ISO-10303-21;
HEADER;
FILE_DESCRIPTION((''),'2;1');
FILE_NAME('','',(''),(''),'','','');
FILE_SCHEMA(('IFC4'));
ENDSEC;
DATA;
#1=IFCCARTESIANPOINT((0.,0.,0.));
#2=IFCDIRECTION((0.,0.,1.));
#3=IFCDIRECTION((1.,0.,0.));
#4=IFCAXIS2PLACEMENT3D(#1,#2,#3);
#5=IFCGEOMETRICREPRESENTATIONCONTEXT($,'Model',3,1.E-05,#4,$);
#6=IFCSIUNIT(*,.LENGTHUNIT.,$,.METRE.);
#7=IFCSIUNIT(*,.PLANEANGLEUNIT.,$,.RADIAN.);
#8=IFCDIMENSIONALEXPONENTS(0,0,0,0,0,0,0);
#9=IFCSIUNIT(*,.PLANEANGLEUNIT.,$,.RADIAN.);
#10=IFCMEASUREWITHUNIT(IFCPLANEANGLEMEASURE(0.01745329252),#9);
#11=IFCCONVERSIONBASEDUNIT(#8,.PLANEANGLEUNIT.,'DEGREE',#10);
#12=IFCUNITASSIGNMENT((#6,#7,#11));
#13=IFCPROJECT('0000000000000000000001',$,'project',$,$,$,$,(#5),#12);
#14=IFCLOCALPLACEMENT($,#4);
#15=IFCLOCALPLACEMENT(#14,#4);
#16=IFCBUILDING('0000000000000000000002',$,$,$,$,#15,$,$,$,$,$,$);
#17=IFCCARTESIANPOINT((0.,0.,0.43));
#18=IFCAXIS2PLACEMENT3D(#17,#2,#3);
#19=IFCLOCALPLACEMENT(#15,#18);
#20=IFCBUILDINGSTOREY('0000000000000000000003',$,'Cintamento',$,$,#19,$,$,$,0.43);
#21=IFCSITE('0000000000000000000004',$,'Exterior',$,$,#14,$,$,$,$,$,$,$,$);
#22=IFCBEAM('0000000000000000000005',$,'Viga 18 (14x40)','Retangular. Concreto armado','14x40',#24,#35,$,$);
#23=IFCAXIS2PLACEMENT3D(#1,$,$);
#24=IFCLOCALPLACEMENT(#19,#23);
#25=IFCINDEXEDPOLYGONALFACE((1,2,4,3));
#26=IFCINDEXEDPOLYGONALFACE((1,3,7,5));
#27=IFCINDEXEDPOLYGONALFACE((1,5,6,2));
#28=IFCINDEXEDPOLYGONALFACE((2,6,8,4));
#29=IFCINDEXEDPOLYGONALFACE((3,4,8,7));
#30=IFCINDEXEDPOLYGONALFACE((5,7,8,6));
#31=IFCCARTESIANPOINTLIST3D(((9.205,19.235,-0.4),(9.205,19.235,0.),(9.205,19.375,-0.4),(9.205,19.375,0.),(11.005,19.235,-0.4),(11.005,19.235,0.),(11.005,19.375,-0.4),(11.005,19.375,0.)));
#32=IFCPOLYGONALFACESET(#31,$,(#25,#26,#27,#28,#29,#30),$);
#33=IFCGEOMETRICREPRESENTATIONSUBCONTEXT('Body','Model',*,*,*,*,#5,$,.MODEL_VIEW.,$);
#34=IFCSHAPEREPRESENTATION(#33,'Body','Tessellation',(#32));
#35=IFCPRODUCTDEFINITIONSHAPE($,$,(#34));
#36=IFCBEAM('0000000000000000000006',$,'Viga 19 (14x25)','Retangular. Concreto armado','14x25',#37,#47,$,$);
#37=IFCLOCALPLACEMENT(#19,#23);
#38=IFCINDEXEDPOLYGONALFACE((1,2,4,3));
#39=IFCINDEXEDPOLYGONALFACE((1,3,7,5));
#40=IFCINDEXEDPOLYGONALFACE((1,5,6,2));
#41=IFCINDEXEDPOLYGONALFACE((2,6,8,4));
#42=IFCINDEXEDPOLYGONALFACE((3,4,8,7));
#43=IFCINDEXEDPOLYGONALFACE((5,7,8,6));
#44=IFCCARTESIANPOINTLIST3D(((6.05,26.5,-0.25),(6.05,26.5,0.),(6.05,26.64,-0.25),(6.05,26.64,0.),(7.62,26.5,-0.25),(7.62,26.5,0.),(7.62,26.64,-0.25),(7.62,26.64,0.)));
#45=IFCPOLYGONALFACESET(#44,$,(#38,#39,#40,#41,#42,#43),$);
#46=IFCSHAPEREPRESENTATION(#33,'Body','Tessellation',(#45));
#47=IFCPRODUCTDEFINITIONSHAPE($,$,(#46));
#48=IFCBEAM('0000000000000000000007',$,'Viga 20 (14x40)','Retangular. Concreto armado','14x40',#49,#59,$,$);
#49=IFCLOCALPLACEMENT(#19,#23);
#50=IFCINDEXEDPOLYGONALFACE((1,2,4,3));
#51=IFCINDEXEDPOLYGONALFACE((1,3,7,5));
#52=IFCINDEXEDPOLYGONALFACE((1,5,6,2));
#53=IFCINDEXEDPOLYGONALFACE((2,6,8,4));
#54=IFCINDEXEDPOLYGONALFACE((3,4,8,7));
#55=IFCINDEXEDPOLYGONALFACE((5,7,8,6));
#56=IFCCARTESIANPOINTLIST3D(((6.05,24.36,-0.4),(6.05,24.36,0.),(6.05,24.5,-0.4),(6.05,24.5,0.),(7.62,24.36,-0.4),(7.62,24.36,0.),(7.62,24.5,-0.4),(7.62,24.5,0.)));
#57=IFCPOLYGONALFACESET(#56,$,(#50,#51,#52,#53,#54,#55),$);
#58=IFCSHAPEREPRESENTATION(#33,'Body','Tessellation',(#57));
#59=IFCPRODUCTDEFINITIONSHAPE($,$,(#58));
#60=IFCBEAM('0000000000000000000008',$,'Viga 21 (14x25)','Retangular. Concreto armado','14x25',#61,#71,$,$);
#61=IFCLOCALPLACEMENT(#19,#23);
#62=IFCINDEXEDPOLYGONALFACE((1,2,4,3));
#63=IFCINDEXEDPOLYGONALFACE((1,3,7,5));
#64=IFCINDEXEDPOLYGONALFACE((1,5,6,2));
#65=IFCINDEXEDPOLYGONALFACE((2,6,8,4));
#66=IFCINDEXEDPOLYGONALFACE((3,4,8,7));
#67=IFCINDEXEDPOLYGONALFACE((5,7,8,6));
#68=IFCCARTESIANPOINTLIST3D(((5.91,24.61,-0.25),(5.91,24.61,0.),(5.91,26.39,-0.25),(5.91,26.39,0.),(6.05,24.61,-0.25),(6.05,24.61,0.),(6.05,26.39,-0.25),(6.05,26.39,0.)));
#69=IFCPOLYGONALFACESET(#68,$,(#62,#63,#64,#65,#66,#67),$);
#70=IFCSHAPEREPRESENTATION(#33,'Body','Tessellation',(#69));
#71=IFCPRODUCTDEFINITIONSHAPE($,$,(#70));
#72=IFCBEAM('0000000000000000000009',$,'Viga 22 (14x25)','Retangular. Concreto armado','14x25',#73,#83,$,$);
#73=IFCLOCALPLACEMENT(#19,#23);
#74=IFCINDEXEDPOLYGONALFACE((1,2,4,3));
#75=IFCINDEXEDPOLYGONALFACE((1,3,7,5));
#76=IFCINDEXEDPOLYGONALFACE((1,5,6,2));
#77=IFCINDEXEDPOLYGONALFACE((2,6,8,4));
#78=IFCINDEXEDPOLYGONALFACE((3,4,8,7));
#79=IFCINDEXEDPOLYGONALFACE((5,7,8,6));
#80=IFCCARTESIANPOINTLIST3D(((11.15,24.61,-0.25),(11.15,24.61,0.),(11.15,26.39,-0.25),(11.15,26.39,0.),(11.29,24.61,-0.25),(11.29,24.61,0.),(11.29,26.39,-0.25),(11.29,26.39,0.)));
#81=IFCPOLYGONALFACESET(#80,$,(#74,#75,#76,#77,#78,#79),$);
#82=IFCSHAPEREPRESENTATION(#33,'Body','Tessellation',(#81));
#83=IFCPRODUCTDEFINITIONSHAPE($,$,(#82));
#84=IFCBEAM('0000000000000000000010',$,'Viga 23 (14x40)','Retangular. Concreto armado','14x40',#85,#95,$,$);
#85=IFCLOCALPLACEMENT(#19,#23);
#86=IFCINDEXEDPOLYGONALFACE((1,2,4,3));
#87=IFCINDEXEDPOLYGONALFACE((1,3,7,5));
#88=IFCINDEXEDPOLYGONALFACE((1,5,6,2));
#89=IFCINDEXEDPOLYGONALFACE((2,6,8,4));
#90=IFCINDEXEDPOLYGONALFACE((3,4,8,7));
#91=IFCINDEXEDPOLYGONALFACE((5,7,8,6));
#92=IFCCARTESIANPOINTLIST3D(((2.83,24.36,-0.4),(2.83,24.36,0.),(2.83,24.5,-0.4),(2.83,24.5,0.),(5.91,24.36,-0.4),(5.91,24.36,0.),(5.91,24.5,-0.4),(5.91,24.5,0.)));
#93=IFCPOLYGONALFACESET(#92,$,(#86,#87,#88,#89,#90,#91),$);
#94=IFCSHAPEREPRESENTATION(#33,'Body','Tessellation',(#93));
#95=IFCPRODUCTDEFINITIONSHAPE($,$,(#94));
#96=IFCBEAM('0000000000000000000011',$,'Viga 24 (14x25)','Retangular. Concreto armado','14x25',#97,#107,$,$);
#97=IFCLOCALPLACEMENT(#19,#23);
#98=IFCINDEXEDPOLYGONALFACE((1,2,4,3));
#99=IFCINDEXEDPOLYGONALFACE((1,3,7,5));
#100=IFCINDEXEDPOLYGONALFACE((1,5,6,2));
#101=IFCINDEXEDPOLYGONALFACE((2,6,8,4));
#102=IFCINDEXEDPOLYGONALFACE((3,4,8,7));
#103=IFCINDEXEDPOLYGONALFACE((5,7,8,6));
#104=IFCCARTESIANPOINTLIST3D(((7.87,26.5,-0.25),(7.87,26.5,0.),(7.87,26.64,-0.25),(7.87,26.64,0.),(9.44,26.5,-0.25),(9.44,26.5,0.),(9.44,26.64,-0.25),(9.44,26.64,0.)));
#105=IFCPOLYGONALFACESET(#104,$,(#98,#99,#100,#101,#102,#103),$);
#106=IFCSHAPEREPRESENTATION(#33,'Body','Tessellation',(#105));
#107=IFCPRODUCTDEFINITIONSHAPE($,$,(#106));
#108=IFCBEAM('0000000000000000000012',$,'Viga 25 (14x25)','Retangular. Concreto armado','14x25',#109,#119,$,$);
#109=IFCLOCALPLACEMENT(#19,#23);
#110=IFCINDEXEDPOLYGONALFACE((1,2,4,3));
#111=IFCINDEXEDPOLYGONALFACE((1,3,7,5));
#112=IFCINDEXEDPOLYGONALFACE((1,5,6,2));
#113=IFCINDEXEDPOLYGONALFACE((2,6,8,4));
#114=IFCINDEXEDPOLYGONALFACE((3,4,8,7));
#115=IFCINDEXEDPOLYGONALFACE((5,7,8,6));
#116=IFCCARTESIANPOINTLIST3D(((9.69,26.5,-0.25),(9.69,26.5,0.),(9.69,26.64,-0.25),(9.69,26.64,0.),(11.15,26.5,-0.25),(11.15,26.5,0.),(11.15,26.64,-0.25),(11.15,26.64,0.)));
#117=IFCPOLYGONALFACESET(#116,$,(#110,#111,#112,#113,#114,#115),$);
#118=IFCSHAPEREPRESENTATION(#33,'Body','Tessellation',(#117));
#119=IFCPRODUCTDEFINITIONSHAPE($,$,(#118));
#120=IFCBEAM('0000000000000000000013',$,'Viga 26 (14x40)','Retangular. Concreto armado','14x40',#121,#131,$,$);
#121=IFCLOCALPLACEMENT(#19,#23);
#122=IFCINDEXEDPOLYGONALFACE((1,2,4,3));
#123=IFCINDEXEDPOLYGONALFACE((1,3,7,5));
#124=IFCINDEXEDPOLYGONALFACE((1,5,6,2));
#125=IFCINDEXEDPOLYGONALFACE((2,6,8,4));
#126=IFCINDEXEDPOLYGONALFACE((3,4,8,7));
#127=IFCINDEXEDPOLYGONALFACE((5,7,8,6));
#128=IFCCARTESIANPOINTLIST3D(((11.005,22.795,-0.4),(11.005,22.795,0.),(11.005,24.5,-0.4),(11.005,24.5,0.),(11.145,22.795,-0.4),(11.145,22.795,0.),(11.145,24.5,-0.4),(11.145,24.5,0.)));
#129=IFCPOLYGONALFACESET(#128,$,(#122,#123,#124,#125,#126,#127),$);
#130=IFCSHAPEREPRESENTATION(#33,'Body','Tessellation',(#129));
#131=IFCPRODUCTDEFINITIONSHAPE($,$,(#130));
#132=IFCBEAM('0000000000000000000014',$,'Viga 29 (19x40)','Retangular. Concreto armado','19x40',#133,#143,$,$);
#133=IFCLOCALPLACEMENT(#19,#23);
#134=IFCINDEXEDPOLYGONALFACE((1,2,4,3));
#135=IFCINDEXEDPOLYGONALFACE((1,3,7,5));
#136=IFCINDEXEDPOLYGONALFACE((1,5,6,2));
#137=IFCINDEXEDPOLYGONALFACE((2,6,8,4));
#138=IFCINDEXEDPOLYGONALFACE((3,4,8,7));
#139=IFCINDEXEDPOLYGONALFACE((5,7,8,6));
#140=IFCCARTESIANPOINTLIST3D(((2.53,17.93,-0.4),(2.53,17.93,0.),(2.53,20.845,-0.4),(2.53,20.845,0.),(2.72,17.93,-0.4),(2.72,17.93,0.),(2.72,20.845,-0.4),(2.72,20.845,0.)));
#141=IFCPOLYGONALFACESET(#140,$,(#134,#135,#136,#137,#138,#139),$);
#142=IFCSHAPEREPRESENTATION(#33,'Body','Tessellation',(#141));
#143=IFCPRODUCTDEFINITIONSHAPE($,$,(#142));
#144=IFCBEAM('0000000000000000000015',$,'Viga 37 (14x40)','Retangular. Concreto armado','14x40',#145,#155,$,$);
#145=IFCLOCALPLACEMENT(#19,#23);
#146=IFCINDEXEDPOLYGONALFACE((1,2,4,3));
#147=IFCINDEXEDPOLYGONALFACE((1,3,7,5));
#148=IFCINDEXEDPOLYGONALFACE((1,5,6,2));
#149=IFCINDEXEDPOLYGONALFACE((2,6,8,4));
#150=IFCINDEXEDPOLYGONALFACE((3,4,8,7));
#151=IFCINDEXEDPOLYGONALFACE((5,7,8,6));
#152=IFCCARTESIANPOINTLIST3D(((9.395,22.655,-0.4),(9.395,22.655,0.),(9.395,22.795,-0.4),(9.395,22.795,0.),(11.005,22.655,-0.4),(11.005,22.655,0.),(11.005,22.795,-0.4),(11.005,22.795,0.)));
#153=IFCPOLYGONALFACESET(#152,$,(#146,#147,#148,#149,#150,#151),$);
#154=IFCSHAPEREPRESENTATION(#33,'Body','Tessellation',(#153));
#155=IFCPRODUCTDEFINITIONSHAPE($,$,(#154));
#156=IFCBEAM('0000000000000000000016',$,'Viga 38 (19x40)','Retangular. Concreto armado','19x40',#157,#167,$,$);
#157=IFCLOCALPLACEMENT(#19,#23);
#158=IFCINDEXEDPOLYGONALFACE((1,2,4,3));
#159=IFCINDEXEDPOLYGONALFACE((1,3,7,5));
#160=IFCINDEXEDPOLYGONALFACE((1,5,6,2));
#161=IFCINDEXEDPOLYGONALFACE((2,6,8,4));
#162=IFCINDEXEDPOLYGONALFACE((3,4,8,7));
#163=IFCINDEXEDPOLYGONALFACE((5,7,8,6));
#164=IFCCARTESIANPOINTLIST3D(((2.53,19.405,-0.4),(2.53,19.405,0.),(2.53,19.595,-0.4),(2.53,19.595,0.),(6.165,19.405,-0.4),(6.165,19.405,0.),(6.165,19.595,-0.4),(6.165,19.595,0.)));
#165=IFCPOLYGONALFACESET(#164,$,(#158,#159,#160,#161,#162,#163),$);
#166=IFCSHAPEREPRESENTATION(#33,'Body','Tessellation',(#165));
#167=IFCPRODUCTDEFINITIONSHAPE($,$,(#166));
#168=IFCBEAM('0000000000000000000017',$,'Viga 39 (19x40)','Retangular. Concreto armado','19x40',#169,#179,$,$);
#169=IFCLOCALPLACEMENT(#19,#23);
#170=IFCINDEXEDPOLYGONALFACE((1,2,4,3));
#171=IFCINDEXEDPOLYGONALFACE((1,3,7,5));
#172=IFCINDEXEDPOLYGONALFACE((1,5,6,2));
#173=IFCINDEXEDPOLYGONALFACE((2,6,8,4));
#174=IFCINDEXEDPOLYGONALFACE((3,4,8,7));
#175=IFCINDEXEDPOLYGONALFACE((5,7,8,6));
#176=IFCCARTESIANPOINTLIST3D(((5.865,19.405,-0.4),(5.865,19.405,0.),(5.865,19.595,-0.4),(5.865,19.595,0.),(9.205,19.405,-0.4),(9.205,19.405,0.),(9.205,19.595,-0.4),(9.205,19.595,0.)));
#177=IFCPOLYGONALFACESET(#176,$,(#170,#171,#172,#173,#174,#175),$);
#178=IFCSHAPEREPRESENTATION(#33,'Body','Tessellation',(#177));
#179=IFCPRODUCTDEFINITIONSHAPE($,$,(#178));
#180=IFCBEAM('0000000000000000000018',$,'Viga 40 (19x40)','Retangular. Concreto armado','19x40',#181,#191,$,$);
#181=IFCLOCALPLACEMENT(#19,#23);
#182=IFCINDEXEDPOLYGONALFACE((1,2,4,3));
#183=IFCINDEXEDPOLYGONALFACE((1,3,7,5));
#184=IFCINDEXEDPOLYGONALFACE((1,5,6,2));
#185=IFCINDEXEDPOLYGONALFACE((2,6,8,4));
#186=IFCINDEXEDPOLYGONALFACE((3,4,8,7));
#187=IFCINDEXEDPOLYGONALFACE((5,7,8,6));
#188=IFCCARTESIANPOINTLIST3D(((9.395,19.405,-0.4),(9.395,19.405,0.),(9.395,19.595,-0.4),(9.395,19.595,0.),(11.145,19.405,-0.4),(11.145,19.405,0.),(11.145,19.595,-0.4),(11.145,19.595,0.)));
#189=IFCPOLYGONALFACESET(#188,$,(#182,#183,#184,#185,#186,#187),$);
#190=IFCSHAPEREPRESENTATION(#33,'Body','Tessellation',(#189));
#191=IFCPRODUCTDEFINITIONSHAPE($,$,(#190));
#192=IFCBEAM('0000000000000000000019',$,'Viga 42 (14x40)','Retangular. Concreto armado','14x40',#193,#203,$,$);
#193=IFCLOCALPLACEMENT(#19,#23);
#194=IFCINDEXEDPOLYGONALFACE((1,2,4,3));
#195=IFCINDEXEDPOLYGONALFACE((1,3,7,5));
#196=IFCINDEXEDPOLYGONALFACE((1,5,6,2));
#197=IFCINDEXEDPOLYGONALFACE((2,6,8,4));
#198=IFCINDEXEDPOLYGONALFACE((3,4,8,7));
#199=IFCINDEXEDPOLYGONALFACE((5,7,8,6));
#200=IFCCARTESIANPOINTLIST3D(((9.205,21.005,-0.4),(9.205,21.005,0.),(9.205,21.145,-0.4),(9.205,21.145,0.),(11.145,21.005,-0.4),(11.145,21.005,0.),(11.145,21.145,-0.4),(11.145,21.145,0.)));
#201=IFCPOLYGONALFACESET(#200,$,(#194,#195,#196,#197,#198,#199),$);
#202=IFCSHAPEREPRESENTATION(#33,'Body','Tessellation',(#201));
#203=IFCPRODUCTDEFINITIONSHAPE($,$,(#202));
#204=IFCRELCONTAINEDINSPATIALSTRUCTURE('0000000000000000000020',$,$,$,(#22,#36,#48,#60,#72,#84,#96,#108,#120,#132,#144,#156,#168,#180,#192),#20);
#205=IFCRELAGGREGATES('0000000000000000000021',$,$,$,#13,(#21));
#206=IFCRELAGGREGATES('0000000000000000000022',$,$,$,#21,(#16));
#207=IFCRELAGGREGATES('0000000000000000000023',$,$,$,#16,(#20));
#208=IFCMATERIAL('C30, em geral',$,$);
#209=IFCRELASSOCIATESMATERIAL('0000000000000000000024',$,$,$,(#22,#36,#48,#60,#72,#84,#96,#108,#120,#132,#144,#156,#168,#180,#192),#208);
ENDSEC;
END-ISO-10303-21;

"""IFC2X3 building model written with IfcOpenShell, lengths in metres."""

from ifc_helpers import new_model, entity, si_unit, converted_unit, frame, frame_2d, origin_with_axes, place, context, subcontext, project, spatial, rectangle, extrude, material, element, save


model = new_model("IFC2X3")

# Units and contexts
model_context = context("Model", 3, precision=1e-05, world=origin_with_axes())
body_context = subcontext(model_context, "Body", "Model", "MODEL_VIEW")
ifc_project = project(units=[si_unit("LENGTHUNIT", "METRE"), si_unit("PLANEANGLEUNIT", "RADIAN"), converted_unit("PLANEANGLEUNIT", "DEGREE", entity("IfcPlaneAngleMeasure", 0.01745329252), si_unit("PLANEANGLEUNIT", "RADIAN"), dimensions=[0, 0, 0, 0, 0, 0, 0])], contexts=[model_context])

# Site, building, storey
site_placement = place(None, origin_with_axes())
site = spatial("IfcSite", under=ifc_project, at=site_placement, Name="Exterior")
building_placement = place(site_placement, origin_with_axes())
building = spatial("IfcBuilding", under=site, at=building_placement)
storey_placement = place(building_placement, frame((0.0, 0.0, 0.43), z_axis=(0.0, 0.0, 1.0), x_axis=(1.0, 0.0, 0.0)))
storey = spatial("IfcBuildingStorey", under=building, at=storey_placement, Name="Cintamento", Elevation=0.43)

# Beams
ifc_material_1 = material(Name="C30, em geral")
beam_1_placement = place(storey_placement, frame((11.005, 19.305, 0.0), z_axis=(-1.0, 0.0, 0.0), x_axis=(0.0, -1.0, 0.0)))
element("IfcBeam", 1, at=beam_1_placement, inside=storey, material=ifc_material_1, Name="Viga 18 (14x40)", Description="Retangular. Concreto armado", ObjectType="14x40", context=body_context, shape_type="SweptSolid", body=[
    extrude(rectangle(XDim=0.14, YDim=0.4, at=frame_2d((0.0, -0.2), x_axis=(1.0, 0.0))), origin_with_axes(), (0.0, 0.0, 1.0), 1.8),
])
beam_2_placement = place(storey_placement, frame((7.62, 26.57, 0.0), z_axis=(-1.0, 0.0, 0.0), x_axis=(0.0, -1.0, 0.0)))
element("IfcBeam", 2, at=beam_2_placement, inside=storey, material=ifc_material_1, Name="Viga 19 (14x25)", Description="Retangular. Concreto armado", ObjectType="14x25", context=body_context, shape_type="SweptSolid", body=[
    extrude(rectangle(XDim=0.14, YDim=0.25, at=frame_2d((0.0, -0.125), x_axis=(1.0, 0.0))), origin_with_axes(), (0.0, 0.0, 1.0), 1.57),
])
beam_3_placement = place(storey_placement, frame((7.62, 24.43, 0.0), z_axis=(-1.0, 0.0, 0.0), x_axis=(0.0, -1.0, 0.0)))
element("IfcBeam", 3, at=beam_3_placement, inside=storey, material=ifc_material_1, Name="Viga 20 (14x40)", Description="Retangular. Concreto armado", ObjectType="14x40", context=body_context, shape_type="SweptSolid", body=[
    extrude(rectangle(XDim=0.14, YDim=0.4, at=frame_2d((0.0, -0.2), x_axis=(1.0, 0.0))), origin_with_axes(), (0.0, 0.0, 1.0), 1.57),
])
for number, where, z_axis, x_axis, name in (
    (4, (5.98, 24.61, 0.0), (0.0, 1.0, 0.0), (-1.0, 0.0, 0.0), "Viga 21 (14x25)"),
    (5, (11.22, 26.39, 0.0), (0.0, -1.0, 0.0), (1.0, 0.0, 0.0), "Viga 22 (14x25)"),
):
    element("IfcBeam", number, at=place(storey_placement, frame(where, z_axis=z_axis, x_axis=x_axis)), inside=storey, material=ifc_material_1, Name=name, Description="Retangular. Concreto armado", ObjectType="14x25", context=body_context, shape_type="SweptSolid", body=[
        extrude(rectangle(XDim=0.14, YDim=0.25, at=frame_2d((0.0, -0.125), x_axis=(1.0, 0.0))), origin_with_axes(), (0.0, 0.0, 1.0), 1.78),
    ])
beam_4_placement = place(storey_placement, frame((5.91, 24.43, 0.0), z_axis=(-1.0, 0.0, 0.0), x_axis=(0.0, -1.0, 0.0)))
element("IfcBeam", 6, at=beam_4_placement, inside=storey, material=ifc_material_1, Name="Viga 23 (14x40)", Description="Retangular. Concreto armado", ObjectType="14x40", context=body_context, shape_type="SweptSolid", body=[
    extrude(rectangle(XDim=0.14, YDim=0.4, at=frame_2d((0.0, -0.2), x_axis=(1.0, 0.0))), origin_with_axes(), (0.0, 0.0, 1.0), 3.08),
])
beam_5_placement = place(storey_placement, frame((7.87, 26.57, 0.0), z_axis=(1.0, 0.0, 0.0), x_axis=(0.0, 1.0, 0.0)))
element("IfcBeam", 7, at=beam_5_placement, inside=storey, material=ifc_material_1, Name="Viga 24 (14x25)", Description="Retangular. Concreto armado", ObjectType="14x25", context=body_context, shape_type="SweptSolid", body=[
    extrude(rectangle(XDim=0.14, YDim=0.25, at=frame_2d((0.0, -0.125), x_axis=(1.0, 0.0))), origin_with_axes(), (0.0, 0.0, 1.0), 1.57),
])
beam_6_placement = place(storey_placement, frame((9.69, 26.57, 0.0), z_axis=(1.0, 0.0, 0.0), x_axis=(0.0, 1.0, 0.0)))
element("IfcBeam", 8, at=beam_6_placement, inside=storey, material=ifc_material_1, Name="Viga 25 (14x25)", Description="Retangular. Concreto armado", ObjectType="14x25", context=body_context, shape_type="SweptSolid", body=[
    extrude(rectangle(XDim=0.14, YDim=0.25, at=frame_2d((0.0, -0.125), x_axis=(1.0, 0.0))), origin_with_axes(), (0.0, 0.0, 1.0), 1.46),
])
beam_7_placement = place(storey_placement, frame((11.075, 22.795, 0.0), z_axis=(0.0, 1.0, 0.0), x_axis=(-1.0, 0.0, 0.0)))
element("IfcBeam", 9, at=beam_7_placement, inside=storey, material=ifc_material_1, Name="Viga 26 (14x40)", Description="Retangular. Concreto armado", ObjectType="14x40", context=body_context, shape_type="SweptSolid", body=[
    extrude(rectangle(XDim=0.14, YDim=0.4, at=frame_2d((0.0, -0.2), x_axis=(1.0, 0.0))), origin_with_axes(), (0.0, 0.0, 1.0), 1.705),
])
beam_8_placement = place(storey_placement, frame((2.625, 17.93, 0.0), z_axis=(0.0, 1.0, 0.0), x_axis=(-1.0, 0.0, 0.0)))
element("IfcBeam", 10, at=beam_8_placement, inside=storey, material=ifc_material_1, Name="Viga 29 (19x40)", Description="Retangular. Concreto armado", ObjectType="19x40", context=body_context, shape_type="SweptSolid", body=[
    extrude(rectangle(XDim=0.19, YDim=0.4, at=frame_2d((0.0, -0.2), x_axis=(1.0, 0.0))), origin_with_axes(), (0.0, 0.0, 1.0), 2.915),
])
beam_9_placement = place(storey_placement, frame((9.395, 22.725, 0.0), z_axis=(1.0, 0.0, 0.0), x_axis=(0.0, 1.0, 0.0)))
element("IfcBeam", 11, at=beam_9_placement, inside=storey, material=ifc_material_1, Name="Viga 37 (14x40)", Description="Retangular. Concreto armado", ObjectType="14x40", context=body_context, shape_type="SweptSolid", body=[
    extrude(rectangle(XDim=0.14, YDim=0.4, at=frame_2d((0.0, -0.2), x_axis=(1.0, 0.0))), origin_with_axes(), (0.0, 0.0, 1.0), 1.61),
])
beam_10_placement = place(storey_placement, frame((6.165, 19.5, 0.0), z_axis=(-1.0, 0.0, 0.0), x_axis=(0.0, -1.0, 0.0)))
element("IfcBeam", 12, at=beam_10_placement, inside=storey, material=ifc_material_1, Name="Viga 38 (19x40)", Description="Retangular. Concreto armado", ObjectType="19x40", context=body_context, shape_type="SweptSolid", body=[
    extrude(rectangle(XDim=0.19, YDim=0.4, at=frame_2d((0.0, -0.2), x_axis=(1.0, 0.0))), origin_with_axes(), (0.0, 0.0, 1.0), 3.635),
])
beam_11_placement = place(storey_placement, frame((5.865, 19.5, 0.0), z_axis=(1.0, 0.0, 0.0), x_axis=(0.0, 1.0, 0.0)))
element("IfcBeam", 13, at=beam_11_placement, inside=storey, material=ifc_material_1, Name="Viga 39 (19x40)", Description="Retangular. Concreto armado", ObjectType="19x40", context=body_context, shape_type="SweptSolid", body=[
    extrude(rectangle(XDim=0.19, YDim=0.4, at=frame_2d((0.0, -0.2), x_axis=(1.0, 0.0))), origin_with_axes(), (0.0, 0.0, 1.0), 3.34),
])
beam_12_placement = place(storey_placement, frame((9.395, 19.5, 0.0), z_axis=(1.0, 0.0, 0.0), x_axis=(0.0, 1.0, 0.0)))
element("IfcBeam", 14, at=beam_12_placement, inside=storey, material=ifc_material_1, Name="Viga 40 (19x40)", Description="Retangular. Concreto armado", ObjectType="19x40", context=body_context, shape_type="SweptSolid", body=[
    extrude(rectangle(XDim=0.19, YDim=0.4, at=frame_2d((0.0, -0.2), x_axis=(1.0, 0.0))), origin_with_axes(), (0.0, 0.0, 1.0), 1.75),
])
beam_13_placement = place(storey_placement, frame((9.205, 21.075, 0.0), z_axis=(1.0, 0.0, 0.0), x_axis=(0.0, 1.0, 0.0)))
element("IfcBeam", 15, at=beam_13_placement, inside=storey, material=ifc_material_1, Name="Viga 42 (14x40)", Description="Retangular. Concreto armado", ObjectType="14x40", context=body_context, shape_type="SweptSolid", body=[
    extrude(rectangle(XDim=0.14, YDim=0.4, at=frame_2d((0.0, -0.2), x_axis=(1.0, 0.0))), origin_with_axes(), (0.0, 0.0, 1.0), 1.94),
])

save(model, "model.ifc")
